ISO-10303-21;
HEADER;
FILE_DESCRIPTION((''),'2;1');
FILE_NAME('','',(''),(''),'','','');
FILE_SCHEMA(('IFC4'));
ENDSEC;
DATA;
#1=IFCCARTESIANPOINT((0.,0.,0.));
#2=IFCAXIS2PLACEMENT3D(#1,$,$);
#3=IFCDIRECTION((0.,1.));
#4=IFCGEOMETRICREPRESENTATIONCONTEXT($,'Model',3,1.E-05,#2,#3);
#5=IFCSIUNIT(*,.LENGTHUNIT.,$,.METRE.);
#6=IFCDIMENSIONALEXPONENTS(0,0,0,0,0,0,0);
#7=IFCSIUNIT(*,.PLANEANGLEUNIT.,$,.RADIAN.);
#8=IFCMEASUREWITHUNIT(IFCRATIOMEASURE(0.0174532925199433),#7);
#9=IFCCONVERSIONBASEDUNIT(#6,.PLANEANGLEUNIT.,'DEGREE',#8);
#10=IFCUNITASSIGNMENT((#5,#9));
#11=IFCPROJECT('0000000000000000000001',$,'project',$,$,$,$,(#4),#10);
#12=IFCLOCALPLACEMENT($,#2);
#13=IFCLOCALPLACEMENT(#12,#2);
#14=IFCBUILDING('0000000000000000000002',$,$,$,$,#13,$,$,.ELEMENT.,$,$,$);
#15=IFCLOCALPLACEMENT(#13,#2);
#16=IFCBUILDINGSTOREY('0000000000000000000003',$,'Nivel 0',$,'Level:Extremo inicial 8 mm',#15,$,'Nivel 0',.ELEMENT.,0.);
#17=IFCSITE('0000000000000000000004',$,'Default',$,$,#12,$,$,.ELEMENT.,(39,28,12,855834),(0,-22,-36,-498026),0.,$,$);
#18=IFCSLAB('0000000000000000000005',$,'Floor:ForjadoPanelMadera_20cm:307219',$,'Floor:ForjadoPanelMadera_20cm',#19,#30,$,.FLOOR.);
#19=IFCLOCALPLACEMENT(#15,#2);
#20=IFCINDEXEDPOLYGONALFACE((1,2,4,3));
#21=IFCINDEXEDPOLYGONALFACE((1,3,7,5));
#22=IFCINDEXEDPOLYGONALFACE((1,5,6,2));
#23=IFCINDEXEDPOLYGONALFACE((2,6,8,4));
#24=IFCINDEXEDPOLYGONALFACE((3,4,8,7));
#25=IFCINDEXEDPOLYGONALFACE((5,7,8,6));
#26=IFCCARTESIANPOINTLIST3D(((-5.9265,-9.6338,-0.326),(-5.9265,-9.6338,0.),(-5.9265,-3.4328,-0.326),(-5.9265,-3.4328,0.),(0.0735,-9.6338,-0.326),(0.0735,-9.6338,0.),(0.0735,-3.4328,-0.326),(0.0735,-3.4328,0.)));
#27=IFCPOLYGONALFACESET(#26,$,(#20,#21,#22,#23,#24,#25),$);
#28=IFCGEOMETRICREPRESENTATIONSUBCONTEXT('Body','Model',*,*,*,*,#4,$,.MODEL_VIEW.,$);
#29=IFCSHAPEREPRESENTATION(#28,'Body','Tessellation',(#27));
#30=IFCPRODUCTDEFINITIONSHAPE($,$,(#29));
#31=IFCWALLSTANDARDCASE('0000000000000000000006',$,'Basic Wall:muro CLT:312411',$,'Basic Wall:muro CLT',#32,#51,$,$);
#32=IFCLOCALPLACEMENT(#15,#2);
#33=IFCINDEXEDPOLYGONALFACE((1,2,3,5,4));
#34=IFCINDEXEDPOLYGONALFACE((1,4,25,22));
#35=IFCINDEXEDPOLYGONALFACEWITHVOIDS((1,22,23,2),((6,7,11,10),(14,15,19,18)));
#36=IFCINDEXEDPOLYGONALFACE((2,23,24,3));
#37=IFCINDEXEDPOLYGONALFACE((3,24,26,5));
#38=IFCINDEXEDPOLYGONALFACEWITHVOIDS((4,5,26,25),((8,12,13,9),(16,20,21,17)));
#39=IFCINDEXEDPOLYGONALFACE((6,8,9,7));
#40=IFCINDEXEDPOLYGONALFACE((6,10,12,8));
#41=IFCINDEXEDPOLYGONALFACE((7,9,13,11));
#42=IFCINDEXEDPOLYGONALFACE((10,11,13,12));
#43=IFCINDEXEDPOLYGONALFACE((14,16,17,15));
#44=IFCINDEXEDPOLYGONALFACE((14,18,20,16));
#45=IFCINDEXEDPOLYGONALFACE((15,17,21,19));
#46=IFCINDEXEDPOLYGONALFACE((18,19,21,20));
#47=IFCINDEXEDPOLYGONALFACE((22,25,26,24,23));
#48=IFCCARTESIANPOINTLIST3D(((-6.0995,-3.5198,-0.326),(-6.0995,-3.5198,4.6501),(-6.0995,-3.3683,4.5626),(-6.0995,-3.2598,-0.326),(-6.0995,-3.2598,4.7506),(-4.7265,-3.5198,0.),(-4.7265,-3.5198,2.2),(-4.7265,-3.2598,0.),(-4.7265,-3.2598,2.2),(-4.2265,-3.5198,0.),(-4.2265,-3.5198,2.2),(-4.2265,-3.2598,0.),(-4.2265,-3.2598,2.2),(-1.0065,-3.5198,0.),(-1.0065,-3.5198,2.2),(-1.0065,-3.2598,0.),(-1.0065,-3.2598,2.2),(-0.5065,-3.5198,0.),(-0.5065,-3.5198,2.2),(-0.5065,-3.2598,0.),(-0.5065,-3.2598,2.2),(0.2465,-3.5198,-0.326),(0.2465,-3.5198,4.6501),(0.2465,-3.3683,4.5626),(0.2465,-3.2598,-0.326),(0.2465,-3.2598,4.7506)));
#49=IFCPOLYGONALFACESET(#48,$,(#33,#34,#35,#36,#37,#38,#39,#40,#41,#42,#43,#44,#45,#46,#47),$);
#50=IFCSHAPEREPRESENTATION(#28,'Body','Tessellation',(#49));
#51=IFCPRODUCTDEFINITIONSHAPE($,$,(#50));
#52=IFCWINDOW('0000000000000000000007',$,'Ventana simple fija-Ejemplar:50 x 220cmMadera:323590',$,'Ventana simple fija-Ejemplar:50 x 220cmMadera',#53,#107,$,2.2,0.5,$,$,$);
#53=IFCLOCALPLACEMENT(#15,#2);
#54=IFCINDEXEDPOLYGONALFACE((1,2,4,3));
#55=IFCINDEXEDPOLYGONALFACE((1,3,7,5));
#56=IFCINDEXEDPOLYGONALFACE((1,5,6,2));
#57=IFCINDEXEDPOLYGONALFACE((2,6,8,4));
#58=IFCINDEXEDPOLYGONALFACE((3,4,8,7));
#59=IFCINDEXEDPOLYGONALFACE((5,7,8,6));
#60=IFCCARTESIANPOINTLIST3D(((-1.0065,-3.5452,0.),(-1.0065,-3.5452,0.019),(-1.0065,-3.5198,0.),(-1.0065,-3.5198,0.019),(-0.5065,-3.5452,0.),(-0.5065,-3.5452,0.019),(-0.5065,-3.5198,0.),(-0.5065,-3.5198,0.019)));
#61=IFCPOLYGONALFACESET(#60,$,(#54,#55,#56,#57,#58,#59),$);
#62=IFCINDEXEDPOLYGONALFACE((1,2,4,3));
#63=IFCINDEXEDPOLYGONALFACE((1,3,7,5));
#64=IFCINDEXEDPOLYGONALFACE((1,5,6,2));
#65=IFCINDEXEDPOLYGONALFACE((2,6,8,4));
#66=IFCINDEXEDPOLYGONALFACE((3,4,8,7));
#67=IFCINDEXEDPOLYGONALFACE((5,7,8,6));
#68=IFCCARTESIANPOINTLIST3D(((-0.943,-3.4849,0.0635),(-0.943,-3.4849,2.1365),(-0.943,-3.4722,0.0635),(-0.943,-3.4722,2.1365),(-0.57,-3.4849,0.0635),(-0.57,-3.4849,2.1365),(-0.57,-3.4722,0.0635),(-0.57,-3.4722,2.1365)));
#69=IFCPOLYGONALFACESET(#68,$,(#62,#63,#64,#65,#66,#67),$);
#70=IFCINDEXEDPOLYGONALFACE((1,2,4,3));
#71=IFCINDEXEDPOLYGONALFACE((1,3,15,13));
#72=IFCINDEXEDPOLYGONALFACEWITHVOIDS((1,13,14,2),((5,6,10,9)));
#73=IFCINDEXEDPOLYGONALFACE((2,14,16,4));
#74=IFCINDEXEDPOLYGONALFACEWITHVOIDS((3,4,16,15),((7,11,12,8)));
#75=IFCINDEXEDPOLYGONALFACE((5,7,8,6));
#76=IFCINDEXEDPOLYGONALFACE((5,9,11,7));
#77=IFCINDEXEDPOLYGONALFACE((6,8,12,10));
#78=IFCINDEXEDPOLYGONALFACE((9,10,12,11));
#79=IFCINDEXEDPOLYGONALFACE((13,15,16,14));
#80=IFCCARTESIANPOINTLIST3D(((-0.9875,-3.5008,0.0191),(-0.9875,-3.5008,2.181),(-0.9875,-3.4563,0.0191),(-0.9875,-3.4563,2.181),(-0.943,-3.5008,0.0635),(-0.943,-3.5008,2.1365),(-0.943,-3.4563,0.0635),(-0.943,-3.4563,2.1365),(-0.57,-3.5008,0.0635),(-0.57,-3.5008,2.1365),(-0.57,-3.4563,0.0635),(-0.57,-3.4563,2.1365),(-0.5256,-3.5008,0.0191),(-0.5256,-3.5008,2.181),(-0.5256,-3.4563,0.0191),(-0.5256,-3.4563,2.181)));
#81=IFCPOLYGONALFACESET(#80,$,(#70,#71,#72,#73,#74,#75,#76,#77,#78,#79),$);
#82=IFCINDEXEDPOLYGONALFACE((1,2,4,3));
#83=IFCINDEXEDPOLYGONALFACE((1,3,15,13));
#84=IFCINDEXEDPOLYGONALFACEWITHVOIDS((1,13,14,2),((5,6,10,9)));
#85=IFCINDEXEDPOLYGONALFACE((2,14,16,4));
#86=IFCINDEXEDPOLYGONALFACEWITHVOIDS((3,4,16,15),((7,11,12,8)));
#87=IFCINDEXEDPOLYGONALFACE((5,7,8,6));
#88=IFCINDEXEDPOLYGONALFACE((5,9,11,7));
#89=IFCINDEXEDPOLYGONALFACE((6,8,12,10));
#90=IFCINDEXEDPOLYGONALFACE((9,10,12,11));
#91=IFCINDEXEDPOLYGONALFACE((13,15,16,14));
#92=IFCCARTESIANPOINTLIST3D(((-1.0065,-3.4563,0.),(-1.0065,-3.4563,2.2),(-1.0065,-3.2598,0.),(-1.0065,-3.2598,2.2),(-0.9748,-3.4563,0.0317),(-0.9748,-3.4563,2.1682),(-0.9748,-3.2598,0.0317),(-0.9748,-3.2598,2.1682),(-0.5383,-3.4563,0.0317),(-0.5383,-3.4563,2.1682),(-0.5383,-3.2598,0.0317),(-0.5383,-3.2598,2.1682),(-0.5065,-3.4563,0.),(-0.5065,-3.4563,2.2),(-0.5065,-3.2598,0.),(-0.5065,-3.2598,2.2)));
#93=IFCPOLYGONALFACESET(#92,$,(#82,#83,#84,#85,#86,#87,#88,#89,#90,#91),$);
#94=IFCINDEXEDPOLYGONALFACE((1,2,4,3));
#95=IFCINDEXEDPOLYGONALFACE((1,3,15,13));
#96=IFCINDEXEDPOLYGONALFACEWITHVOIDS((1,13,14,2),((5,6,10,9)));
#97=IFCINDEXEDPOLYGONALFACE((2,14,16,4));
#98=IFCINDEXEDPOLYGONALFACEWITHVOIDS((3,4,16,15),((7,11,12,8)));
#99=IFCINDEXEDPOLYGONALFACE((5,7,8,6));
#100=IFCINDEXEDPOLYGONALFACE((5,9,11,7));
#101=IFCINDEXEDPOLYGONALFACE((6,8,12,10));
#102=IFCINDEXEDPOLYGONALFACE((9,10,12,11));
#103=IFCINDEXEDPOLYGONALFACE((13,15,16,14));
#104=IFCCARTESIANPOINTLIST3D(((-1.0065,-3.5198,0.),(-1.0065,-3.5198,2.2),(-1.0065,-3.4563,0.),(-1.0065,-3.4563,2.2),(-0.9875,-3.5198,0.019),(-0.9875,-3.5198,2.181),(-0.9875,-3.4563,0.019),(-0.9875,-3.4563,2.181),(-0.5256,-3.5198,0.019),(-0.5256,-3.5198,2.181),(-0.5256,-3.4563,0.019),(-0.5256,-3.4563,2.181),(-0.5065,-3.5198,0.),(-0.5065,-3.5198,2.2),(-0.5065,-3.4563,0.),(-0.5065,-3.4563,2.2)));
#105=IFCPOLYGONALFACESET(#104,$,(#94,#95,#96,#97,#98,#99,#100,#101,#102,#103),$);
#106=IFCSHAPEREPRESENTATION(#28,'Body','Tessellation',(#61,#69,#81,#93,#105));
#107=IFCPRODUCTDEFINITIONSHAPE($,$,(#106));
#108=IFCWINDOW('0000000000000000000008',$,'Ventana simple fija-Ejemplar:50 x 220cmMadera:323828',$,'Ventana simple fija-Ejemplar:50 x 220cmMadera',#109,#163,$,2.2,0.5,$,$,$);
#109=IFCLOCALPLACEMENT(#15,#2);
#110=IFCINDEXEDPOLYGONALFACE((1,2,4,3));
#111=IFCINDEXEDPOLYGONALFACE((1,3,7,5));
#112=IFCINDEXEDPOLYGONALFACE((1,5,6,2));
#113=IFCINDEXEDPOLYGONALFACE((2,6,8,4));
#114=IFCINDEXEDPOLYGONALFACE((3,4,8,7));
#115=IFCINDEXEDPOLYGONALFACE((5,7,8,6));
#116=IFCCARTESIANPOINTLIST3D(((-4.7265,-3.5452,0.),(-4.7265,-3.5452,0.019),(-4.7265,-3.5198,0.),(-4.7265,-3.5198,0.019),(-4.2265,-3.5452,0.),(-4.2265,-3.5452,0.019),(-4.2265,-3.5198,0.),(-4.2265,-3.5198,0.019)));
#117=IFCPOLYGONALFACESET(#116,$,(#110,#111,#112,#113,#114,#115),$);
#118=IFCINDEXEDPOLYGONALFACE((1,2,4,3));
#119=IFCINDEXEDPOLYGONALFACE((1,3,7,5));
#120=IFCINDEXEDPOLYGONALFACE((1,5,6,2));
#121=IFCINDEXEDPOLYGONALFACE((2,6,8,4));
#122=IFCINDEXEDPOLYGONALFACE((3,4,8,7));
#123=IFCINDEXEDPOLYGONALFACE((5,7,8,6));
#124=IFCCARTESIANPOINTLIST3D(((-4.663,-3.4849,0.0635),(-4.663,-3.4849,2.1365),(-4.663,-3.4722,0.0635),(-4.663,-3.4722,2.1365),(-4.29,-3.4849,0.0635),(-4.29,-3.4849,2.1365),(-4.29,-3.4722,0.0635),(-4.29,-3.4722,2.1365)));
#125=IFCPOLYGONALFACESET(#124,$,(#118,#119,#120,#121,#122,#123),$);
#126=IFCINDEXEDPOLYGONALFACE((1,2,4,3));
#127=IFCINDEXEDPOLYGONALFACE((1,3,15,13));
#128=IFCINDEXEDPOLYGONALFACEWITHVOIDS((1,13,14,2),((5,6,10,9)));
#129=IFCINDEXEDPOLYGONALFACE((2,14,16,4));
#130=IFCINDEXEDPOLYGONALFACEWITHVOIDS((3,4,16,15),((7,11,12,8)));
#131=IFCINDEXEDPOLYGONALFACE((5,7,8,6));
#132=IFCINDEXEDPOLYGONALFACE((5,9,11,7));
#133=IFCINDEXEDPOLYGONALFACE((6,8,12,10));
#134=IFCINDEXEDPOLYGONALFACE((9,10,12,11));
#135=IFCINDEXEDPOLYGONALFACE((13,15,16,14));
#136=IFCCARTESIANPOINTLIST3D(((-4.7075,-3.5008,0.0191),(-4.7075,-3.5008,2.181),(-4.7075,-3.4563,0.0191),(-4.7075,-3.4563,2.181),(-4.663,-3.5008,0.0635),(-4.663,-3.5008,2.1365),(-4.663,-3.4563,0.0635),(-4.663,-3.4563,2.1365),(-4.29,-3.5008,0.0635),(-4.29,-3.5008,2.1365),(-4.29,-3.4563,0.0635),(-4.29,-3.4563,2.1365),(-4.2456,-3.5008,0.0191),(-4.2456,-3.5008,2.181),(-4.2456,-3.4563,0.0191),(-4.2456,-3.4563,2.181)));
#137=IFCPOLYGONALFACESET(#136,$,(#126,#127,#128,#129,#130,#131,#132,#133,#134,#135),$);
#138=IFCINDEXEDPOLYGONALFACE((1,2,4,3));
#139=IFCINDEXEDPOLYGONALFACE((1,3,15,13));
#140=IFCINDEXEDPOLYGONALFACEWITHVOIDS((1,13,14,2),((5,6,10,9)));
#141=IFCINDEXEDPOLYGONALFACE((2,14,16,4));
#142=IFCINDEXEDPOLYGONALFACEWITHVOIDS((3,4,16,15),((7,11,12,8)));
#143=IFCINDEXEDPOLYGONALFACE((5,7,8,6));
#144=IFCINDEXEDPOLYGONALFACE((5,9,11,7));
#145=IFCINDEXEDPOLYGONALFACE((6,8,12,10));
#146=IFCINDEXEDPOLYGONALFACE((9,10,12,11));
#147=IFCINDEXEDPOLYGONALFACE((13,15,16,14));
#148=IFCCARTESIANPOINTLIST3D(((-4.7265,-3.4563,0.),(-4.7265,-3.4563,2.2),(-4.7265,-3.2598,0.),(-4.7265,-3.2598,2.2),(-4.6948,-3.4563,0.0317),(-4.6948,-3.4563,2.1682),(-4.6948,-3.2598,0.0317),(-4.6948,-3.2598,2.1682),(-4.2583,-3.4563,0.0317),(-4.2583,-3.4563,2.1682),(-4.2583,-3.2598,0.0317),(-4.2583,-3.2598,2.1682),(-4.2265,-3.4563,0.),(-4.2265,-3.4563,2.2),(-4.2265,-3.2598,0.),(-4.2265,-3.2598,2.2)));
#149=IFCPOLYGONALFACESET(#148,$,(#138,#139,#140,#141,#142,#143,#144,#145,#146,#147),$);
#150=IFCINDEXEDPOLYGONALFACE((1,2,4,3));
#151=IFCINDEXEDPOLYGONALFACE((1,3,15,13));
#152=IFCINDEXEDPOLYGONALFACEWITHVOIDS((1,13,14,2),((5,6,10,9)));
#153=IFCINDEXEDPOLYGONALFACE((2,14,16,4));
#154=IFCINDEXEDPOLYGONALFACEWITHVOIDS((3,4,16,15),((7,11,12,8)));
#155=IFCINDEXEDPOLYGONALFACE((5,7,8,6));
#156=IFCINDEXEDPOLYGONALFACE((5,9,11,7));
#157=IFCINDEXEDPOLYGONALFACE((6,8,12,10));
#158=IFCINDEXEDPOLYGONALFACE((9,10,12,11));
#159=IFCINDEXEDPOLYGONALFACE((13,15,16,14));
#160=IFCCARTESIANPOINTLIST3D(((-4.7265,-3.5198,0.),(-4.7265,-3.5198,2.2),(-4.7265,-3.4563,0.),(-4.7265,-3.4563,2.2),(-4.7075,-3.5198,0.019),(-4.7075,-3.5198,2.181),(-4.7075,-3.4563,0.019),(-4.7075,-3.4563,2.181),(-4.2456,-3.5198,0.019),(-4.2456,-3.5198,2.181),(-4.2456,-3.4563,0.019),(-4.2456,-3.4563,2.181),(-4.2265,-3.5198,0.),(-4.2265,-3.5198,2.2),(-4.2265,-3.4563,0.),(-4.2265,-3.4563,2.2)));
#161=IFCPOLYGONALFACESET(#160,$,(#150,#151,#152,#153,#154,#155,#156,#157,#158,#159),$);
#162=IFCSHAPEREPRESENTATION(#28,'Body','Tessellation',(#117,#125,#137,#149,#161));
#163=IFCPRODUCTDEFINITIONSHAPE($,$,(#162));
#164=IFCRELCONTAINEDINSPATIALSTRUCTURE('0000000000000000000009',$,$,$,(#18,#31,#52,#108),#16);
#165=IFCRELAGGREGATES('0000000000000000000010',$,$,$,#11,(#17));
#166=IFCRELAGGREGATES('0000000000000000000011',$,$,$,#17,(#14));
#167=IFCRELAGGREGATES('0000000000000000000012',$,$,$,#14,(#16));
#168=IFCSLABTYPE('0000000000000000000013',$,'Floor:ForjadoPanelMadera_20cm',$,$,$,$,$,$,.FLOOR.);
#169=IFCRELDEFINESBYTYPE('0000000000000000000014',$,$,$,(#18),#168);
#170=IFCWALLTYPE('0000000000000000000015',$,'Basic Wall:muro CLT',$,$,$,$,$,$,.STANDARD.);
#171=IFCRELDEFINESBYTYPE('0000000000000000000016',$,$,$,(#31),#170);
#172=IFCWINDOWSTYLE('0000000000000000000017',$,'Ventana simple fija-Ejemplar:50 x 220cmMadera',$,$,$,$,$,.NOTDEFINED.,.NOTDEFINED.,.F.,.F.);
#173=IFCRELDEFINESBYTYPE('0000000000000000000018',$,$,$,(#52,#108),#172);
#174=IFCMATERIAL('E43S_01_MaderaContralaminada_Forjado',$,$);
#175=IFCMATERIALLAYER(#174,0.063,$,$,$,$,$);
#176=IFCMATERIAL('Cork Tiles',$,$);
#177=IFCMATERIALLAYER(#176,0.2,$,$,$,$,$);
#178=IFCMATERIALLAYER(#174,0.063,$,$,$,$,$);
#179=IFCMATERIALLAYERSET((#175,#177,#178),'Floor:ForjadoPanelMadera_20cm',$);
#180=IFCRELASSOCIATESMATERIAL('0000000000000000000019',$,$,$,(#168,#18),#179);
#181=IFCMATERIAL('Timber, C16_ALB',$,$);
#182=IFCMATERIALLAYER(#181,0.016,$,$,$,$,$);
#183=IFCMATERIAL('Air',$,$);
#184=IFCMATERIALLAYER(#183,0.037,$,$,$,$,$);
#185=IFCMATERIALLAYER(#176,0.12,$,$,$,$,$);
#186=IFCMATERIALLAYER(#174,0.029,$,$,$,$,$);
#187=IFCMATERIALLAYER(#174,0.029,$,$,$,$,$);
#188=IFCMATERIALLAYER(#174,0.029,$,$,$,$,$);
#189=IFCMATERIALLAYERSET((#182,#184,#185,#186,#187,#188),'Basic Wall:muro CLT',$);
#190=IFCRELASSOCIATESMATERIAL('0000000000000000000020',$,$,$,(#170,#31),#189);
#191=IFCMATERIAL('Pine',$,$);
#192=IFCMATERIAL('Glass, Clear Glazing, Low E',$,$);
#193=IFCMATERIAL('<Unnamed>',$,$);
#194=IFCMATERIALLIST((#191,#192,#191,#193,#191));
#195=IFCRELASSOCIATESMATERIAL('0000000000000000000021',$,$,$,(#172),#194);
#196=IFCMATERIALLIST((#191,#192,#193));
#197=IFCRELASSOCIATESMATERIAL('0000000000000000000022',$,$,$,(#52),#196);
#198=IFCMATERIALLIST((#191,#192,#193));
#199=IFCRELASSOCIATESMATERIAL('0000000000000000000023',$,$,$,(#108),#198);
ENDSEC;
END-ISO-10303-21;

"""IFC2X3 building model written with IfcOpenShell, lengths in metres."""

from ifc_helpers import new_model, entity, si_unit, converted_unit, direction, frame, frame_2d, origin, origin_2d_with_axis, place, context, subcontext, project, spatial, polyline, rectangle, outline, extrude, clip, bounded_halfspace, source, transform, mapped, material, material_list, layer, layer_set, layer_usage, type_object, type_shapes, element, fill, save


model = new_model("IFC2X3")

# Units and contexts
model_context = context("Model", 3, precision=1e-05, world=origin(), true_north=direction((0.0, 1.0)))
body_context = subcontext(model_context, "Body", "Model", "MODEL_VIEW")
ifc_project = project(units=[si_unit("LENGTHUNIT", "METRE"), converted_unit("PLANEANGLEUNIT", "DEGREE", entity("IfcRatioMeasure", 0.0174532925199433), si_unit("PLANEANGLEUNIT", "RADIAN"), dimensions=[0, 0, 0, 0, 0, 0, 0])], contexts=[model_context])

# Site, building, storey
site_placement = place(None, origin())
site = spatial("IfcSite", under=ifc_project, at=site_placement, Name="Default", CompositionType="ELEMENT", RefLatitude=(39, 28, 12, 855834), RefLongitude=(0, -22, -36, -498026), RefElevation=0.0)
building_placement = place(site_placement, origin())
building = spatial("IfcBuilding", under=site, at=building_placement, CompositionType="ELEMENT")
storey_placement = place(building_placement, origin())
storey = spatial("IfcBuildingStorey", under=building, at=storey_placement, Name="Nivel 0", ObjectType="Level:Extremo inicial 8 mm", LongName="Nivel 0", CompositionType="ELEMENT", Elevation=0.0)

# Slab
ifc_material_1 = material(Name="E43S_01_MaderaContralaminada_Forjado")
ifc_layer_1 = layer(ifc_material_1, 0.063)
ifc_material_2 = material(Name="Cork Tiles")
ifc_layer_2 = layer(ifc_material_2, 0.2)
ifc_layer_3 = layer(ifc_material_1, 0.063)
ifc_layer_set_1 = layer_set([ifc_layer_1, ifc_layer_2, ifc_layer_3], Name="Floor:ForjadoPanelMadera_20cm")
ifc_layer_usage_1 = layer_usage(ifc_layer_set_1, "AXIS3", "POSITIVE", 0.0)
slab_type = type_object("IfcSlabType", Name="Floor:ForjadoPanelMadera_20cm", PredefinedType="FLOOR", material=ifc_layer_set_1)
slab_placement = place(storey_placement, origin())
element("IfcSlab", 1, at=slab_placement, inside=storey, type_object=slab_type, material=ifc_layer_usage_1, Name="Floor:ForjadoPanelMadera_20cm:307219", ObjectType="Floor:ForjadoPanelMadera_20cm", PredefinedType="FLOOR", context=body_context, shape_type="SweptSolid", body=[
    extrude(rectangle(XDim=6.201, YDim=6.0, at=frame_2d((0.0, 0.0), x_axis=(1.0, 0.0))), frame((-2.9265, -6.5333, 0.0), z_axis=(0.0, 0.0, -1.0), x_axis=(0.0, 1.0, 0.0)), (0.0, 0.0, 1.0), 0.326),
])

# Wall, openings, windows
ifc_material_3 = material(Name="Timber, C16_ALB")
ifc_layer_4 = layer(ifc_material_3, 0.016)
ifc_material_4 = material(Name="Air")
ifc_layer_5 = layer(ifc_material_4, 0.037)
ifc_layer_6 = layer(ifc_material_2, 0.12)
ifc_layer_7 = layer(ifc_material_1, 0.029)
ifc_layer_8 = layer(ifc_material_1, 0.029)
ifc_layer_9 = layer(ifc_material_1, 0.029)
ifc_layer_set_2 = layer_set([ifc_layer_4, ifc_layer_5, ifc_layer_6, ifc_layer_7, ifc_layer_8, ifc_layer_9], Name="Basic Wall:muro CLT")
ifc_layer_usage_2 = layer_usage(ifc_layer_set_2, "AXIS2", "NEGATIVE", 0.13)
wall_type = type_object("IfcWallType", Name="Basic Wall:muro CLT", PredefinedType="STANDARD", material=ifc_layer_set_2)
wall_1_placement = place(storey_placement, frame((-6.0995, -3.3898, -0.326)))
wall_1 = element("IfcWallStandardCase", 2, at=wall_1_placement, inside=storey, type_object=wall_type, material=ifc_layer_usage_2, Name="Basic Wall:muro CLT:312411", ObjectType="Basic Wall:muro CLT", context=body_context, shape_type="Clipping", body=[
    clip(clip(extrude(rectangle(XDim=6.346, YDim=0.26, at=frame_2d((3.173, 0.0), x_axis=(-1.0, 0.0))), origin(), (0.0, 0.0, 1.0), 5.0766), bounded_halfspace(frame((0.0, -0.13, 4.9761), z_axis=(0.0, 0.5, 0.866025), x_axis=(-1.0, 0.0, 0.0)), False, frame((0.0, -0.13, 4.9761)), polyline([(0.0, 0.0), (0.26, 0.0), (6.086, 0.0), (6.346, 0.0), (6.346, 0.1515), (0.0, 0.1515), (0.0, 0.0)]))), bounded_halfspace(frame((6.346, 0.0215, 4.8886), z_axis=(0.0, -0.866025, 0.5), x_axis=(-1.0, 0.0, 0.0)), False, frame((6.346, 0.0215, 4.8886)), polyline([(0.0, 0.0), (0.0, 0.1085), (-6.346, 0.1085), (-6.346, 0.0), (0.0, 0.0)]))),
])
opening_1_placement = place(wall_1_placement, frame((5.593, 0.13, 0.326)))
opening_1 = element("IfcOpeningElement", 3, at=opening_1_placement, cuts=wall_1, ObjectType="Opening", context=body_context, shape_type="SweptSolid", body=[
    extrude(rectangle(XDim=2.2, YDim=0.5, at=frame_2d((1.1, 0.25), x_axis=(-1.0, 0.0))), frame((0.0, 0.0, 0.0), z_axis=(0.0, -1.0, 0.0), x_axis=(0.0, 0.0, 1.0)), (0.0, 0.0, 1.0), 0.26),
])
opening_2_placement = place(wall_1_placement, frame((1.873, 0.13, 0.326)))
opening_2 = element("IfcOpeningElement", 4, at=opening_2_placement, cuts=wall_1, ObjectType="Opening", context=body_context, shape_type="SweptSolid", body=[
    extrude(rectangle(XDim=2.2, YDim=0.5, at=frame_2d((1.1, 0.25), x_axis=(-1.0, 0.0))), frame((0.0, 0.0, 0.0), z_axis=(0.0, -1.0, 0.0), x_axis=(0.0, 0.0, 1.0)), (0.0, 0.0, 1.0), 0.26),
])
ifc_material_5 = material(Name="Pine")
ifc_material_6 = material(Name="Glass, Clear Glazing, Low E")
ifc_material_7 = material(Name="<Unnamed>")
ifc_material_list_1 = material_list([ifc_material_5, ifc_material_6, ifc_material_7])
ifc_material_list_2 = material_list([ifc_material_5, ifc_material_6, ifc_material_5, ifc_material_7, ifc_material_5])
window_style = type_object("IfcWindowStyle", Name="Ventana simple fija-Ejemplar:50 x 220cmMadera", ConstructionType="NOTDEFINED", OperationType="NOTDEFINED", ParameterTakesPrecedence=False, Sizeable=False, material=ifc_material_list_2)
shared_shape = source(origin(), body_context, "Body", "SweptSolid", [
    extrude(rectangle(XDim=0.5, YDim=0.0254, at=frame_2d((0.0, 0.0), x_axis=(1.0, 0.0))), frame((0.3262, 0.2727, 0.0), z_axis=(0.0, 0.0, 1.0), x_axis=(-1.0, 0.0, 0.0)), (0.0, 0.0, 1.0), 0.019),
    extrude(rectangle(XDim=0.373, YDim=0.0127, at=origin_2d_with_axis()), frame((0.3262, 0.2188, 0.0635)), (0.0, 0.0, 1.0), 2.073),
    extrude(outline(polyline([(-0.2309, -1.081), (0.2309, -1.081), (0.2309, 1.081), (-0.2309, 1.081), (-0.2309, -1.081)]), holes=[polyline([(-0.1865, -1.0365), (-0.1865, 1.0365), (0.1865, 1.0365), (0.1865, -1.0365), (-0.1865, -1.0365)])]), frame((0.3262, 0.241, 1.1), z_axis=(0.0, -1.0, 0.0), x_axis=(-1.0, 0.0, 0.0)), (0.0, 0.0, 1.0), 0.0445),
    extrude(outline(polyline([(-0.25, -1.1), (0.25, -1.1), (0.25, 1.1), (-0.25, 1.1), (-0.25, -1.1)]), holes=[polyline([(-0.2182, -1.0682), (-0.2182, 1.0683), (0.2182, 1.0683), (0.2182, -1.0682), (-0.2182, -1.0682)])]), frame((0.3262, 0.1966, 1.1), z_axis=(0.0, -1.0, 0.0), x_axis=(-1.0, 0.0, 0.0)), (0.0, 0.0, 1.0), 0.1966),
    extrude(outline(polyline([(-1.1, -0.25), (1.1, -0.25), (1.1, 0.25), (-1.1, 0.25), (-1.1, -0.25)]), holes=[polyline([(-1.081, -0.2309), (-1.081, 0.2309), (1.081, 0.2309), (1.081, -0.2309), (-1.081, -0.2309)])]), frame((0.3262, 0.26, 1.1), z_axis=(0.0, -1.0, 0.0), x_axis=(0.0, 0.0, -1.0)), (0.0, 0.0, 1.0), 0.0635),
])
type_shapes(window_style, [shared_shape])
window_1_placement = place(opening_1_placement, frame((0.0762, 0.0, 0.0), z_axis=(0.0, 0.0, 1.0), x_axis=(-1.0, 0.0, 0.0)))
window_1 = element("IfcWindow", 5, at=window_1_placement, inside=storey, type_object=window_style, material=ifc_material_list_1, Name="Ventana simple fija-Ejemplar:50 x 220cmMadera:323590", ObjectType="Ventana simple fija-Ejemplar:50 x 220cmMadera", OverallHeight=2.2, OverallWidth=0.5, context=body_context, shape_type="MappedRepresentation", body=[
    mapped(shared_shape, transform((0.0, 0.0, 0.0), scale=1.0)),
])
fill(opening_1, window_1)
ifc_material_list_3 = material_list([ifc_material_5, ifc_material_6, ifc_material_7])
window_2_placement = place(opening_2_placement, frame((0.0762, 0.0, 0.0), z_axis=(0.0, 0.0, 1.0), x_axis=(-1.0, 0.0, 0.0)))
window_2 = element("IfcWindow", 6, at=window_2_placement, inside=storey, type_object=window_style, material=ifc_material_list_3, Name="Ventana simple fija-Ejemplar:50 x 220cmMadera:323828", ObjectType="Ventana simple fija-Ejemplar:50 x 220cmMadera", OverallHeight=2.2, OverallWidth=0.5, context=body_context, shape_type="MappedRepresentation", body=[
    mapped(shared_shape, transform((0.0, 0.0, 0.0), scale=1.0)),
])
fill(opening_2, window_2)

save(model, "model.ifc")
